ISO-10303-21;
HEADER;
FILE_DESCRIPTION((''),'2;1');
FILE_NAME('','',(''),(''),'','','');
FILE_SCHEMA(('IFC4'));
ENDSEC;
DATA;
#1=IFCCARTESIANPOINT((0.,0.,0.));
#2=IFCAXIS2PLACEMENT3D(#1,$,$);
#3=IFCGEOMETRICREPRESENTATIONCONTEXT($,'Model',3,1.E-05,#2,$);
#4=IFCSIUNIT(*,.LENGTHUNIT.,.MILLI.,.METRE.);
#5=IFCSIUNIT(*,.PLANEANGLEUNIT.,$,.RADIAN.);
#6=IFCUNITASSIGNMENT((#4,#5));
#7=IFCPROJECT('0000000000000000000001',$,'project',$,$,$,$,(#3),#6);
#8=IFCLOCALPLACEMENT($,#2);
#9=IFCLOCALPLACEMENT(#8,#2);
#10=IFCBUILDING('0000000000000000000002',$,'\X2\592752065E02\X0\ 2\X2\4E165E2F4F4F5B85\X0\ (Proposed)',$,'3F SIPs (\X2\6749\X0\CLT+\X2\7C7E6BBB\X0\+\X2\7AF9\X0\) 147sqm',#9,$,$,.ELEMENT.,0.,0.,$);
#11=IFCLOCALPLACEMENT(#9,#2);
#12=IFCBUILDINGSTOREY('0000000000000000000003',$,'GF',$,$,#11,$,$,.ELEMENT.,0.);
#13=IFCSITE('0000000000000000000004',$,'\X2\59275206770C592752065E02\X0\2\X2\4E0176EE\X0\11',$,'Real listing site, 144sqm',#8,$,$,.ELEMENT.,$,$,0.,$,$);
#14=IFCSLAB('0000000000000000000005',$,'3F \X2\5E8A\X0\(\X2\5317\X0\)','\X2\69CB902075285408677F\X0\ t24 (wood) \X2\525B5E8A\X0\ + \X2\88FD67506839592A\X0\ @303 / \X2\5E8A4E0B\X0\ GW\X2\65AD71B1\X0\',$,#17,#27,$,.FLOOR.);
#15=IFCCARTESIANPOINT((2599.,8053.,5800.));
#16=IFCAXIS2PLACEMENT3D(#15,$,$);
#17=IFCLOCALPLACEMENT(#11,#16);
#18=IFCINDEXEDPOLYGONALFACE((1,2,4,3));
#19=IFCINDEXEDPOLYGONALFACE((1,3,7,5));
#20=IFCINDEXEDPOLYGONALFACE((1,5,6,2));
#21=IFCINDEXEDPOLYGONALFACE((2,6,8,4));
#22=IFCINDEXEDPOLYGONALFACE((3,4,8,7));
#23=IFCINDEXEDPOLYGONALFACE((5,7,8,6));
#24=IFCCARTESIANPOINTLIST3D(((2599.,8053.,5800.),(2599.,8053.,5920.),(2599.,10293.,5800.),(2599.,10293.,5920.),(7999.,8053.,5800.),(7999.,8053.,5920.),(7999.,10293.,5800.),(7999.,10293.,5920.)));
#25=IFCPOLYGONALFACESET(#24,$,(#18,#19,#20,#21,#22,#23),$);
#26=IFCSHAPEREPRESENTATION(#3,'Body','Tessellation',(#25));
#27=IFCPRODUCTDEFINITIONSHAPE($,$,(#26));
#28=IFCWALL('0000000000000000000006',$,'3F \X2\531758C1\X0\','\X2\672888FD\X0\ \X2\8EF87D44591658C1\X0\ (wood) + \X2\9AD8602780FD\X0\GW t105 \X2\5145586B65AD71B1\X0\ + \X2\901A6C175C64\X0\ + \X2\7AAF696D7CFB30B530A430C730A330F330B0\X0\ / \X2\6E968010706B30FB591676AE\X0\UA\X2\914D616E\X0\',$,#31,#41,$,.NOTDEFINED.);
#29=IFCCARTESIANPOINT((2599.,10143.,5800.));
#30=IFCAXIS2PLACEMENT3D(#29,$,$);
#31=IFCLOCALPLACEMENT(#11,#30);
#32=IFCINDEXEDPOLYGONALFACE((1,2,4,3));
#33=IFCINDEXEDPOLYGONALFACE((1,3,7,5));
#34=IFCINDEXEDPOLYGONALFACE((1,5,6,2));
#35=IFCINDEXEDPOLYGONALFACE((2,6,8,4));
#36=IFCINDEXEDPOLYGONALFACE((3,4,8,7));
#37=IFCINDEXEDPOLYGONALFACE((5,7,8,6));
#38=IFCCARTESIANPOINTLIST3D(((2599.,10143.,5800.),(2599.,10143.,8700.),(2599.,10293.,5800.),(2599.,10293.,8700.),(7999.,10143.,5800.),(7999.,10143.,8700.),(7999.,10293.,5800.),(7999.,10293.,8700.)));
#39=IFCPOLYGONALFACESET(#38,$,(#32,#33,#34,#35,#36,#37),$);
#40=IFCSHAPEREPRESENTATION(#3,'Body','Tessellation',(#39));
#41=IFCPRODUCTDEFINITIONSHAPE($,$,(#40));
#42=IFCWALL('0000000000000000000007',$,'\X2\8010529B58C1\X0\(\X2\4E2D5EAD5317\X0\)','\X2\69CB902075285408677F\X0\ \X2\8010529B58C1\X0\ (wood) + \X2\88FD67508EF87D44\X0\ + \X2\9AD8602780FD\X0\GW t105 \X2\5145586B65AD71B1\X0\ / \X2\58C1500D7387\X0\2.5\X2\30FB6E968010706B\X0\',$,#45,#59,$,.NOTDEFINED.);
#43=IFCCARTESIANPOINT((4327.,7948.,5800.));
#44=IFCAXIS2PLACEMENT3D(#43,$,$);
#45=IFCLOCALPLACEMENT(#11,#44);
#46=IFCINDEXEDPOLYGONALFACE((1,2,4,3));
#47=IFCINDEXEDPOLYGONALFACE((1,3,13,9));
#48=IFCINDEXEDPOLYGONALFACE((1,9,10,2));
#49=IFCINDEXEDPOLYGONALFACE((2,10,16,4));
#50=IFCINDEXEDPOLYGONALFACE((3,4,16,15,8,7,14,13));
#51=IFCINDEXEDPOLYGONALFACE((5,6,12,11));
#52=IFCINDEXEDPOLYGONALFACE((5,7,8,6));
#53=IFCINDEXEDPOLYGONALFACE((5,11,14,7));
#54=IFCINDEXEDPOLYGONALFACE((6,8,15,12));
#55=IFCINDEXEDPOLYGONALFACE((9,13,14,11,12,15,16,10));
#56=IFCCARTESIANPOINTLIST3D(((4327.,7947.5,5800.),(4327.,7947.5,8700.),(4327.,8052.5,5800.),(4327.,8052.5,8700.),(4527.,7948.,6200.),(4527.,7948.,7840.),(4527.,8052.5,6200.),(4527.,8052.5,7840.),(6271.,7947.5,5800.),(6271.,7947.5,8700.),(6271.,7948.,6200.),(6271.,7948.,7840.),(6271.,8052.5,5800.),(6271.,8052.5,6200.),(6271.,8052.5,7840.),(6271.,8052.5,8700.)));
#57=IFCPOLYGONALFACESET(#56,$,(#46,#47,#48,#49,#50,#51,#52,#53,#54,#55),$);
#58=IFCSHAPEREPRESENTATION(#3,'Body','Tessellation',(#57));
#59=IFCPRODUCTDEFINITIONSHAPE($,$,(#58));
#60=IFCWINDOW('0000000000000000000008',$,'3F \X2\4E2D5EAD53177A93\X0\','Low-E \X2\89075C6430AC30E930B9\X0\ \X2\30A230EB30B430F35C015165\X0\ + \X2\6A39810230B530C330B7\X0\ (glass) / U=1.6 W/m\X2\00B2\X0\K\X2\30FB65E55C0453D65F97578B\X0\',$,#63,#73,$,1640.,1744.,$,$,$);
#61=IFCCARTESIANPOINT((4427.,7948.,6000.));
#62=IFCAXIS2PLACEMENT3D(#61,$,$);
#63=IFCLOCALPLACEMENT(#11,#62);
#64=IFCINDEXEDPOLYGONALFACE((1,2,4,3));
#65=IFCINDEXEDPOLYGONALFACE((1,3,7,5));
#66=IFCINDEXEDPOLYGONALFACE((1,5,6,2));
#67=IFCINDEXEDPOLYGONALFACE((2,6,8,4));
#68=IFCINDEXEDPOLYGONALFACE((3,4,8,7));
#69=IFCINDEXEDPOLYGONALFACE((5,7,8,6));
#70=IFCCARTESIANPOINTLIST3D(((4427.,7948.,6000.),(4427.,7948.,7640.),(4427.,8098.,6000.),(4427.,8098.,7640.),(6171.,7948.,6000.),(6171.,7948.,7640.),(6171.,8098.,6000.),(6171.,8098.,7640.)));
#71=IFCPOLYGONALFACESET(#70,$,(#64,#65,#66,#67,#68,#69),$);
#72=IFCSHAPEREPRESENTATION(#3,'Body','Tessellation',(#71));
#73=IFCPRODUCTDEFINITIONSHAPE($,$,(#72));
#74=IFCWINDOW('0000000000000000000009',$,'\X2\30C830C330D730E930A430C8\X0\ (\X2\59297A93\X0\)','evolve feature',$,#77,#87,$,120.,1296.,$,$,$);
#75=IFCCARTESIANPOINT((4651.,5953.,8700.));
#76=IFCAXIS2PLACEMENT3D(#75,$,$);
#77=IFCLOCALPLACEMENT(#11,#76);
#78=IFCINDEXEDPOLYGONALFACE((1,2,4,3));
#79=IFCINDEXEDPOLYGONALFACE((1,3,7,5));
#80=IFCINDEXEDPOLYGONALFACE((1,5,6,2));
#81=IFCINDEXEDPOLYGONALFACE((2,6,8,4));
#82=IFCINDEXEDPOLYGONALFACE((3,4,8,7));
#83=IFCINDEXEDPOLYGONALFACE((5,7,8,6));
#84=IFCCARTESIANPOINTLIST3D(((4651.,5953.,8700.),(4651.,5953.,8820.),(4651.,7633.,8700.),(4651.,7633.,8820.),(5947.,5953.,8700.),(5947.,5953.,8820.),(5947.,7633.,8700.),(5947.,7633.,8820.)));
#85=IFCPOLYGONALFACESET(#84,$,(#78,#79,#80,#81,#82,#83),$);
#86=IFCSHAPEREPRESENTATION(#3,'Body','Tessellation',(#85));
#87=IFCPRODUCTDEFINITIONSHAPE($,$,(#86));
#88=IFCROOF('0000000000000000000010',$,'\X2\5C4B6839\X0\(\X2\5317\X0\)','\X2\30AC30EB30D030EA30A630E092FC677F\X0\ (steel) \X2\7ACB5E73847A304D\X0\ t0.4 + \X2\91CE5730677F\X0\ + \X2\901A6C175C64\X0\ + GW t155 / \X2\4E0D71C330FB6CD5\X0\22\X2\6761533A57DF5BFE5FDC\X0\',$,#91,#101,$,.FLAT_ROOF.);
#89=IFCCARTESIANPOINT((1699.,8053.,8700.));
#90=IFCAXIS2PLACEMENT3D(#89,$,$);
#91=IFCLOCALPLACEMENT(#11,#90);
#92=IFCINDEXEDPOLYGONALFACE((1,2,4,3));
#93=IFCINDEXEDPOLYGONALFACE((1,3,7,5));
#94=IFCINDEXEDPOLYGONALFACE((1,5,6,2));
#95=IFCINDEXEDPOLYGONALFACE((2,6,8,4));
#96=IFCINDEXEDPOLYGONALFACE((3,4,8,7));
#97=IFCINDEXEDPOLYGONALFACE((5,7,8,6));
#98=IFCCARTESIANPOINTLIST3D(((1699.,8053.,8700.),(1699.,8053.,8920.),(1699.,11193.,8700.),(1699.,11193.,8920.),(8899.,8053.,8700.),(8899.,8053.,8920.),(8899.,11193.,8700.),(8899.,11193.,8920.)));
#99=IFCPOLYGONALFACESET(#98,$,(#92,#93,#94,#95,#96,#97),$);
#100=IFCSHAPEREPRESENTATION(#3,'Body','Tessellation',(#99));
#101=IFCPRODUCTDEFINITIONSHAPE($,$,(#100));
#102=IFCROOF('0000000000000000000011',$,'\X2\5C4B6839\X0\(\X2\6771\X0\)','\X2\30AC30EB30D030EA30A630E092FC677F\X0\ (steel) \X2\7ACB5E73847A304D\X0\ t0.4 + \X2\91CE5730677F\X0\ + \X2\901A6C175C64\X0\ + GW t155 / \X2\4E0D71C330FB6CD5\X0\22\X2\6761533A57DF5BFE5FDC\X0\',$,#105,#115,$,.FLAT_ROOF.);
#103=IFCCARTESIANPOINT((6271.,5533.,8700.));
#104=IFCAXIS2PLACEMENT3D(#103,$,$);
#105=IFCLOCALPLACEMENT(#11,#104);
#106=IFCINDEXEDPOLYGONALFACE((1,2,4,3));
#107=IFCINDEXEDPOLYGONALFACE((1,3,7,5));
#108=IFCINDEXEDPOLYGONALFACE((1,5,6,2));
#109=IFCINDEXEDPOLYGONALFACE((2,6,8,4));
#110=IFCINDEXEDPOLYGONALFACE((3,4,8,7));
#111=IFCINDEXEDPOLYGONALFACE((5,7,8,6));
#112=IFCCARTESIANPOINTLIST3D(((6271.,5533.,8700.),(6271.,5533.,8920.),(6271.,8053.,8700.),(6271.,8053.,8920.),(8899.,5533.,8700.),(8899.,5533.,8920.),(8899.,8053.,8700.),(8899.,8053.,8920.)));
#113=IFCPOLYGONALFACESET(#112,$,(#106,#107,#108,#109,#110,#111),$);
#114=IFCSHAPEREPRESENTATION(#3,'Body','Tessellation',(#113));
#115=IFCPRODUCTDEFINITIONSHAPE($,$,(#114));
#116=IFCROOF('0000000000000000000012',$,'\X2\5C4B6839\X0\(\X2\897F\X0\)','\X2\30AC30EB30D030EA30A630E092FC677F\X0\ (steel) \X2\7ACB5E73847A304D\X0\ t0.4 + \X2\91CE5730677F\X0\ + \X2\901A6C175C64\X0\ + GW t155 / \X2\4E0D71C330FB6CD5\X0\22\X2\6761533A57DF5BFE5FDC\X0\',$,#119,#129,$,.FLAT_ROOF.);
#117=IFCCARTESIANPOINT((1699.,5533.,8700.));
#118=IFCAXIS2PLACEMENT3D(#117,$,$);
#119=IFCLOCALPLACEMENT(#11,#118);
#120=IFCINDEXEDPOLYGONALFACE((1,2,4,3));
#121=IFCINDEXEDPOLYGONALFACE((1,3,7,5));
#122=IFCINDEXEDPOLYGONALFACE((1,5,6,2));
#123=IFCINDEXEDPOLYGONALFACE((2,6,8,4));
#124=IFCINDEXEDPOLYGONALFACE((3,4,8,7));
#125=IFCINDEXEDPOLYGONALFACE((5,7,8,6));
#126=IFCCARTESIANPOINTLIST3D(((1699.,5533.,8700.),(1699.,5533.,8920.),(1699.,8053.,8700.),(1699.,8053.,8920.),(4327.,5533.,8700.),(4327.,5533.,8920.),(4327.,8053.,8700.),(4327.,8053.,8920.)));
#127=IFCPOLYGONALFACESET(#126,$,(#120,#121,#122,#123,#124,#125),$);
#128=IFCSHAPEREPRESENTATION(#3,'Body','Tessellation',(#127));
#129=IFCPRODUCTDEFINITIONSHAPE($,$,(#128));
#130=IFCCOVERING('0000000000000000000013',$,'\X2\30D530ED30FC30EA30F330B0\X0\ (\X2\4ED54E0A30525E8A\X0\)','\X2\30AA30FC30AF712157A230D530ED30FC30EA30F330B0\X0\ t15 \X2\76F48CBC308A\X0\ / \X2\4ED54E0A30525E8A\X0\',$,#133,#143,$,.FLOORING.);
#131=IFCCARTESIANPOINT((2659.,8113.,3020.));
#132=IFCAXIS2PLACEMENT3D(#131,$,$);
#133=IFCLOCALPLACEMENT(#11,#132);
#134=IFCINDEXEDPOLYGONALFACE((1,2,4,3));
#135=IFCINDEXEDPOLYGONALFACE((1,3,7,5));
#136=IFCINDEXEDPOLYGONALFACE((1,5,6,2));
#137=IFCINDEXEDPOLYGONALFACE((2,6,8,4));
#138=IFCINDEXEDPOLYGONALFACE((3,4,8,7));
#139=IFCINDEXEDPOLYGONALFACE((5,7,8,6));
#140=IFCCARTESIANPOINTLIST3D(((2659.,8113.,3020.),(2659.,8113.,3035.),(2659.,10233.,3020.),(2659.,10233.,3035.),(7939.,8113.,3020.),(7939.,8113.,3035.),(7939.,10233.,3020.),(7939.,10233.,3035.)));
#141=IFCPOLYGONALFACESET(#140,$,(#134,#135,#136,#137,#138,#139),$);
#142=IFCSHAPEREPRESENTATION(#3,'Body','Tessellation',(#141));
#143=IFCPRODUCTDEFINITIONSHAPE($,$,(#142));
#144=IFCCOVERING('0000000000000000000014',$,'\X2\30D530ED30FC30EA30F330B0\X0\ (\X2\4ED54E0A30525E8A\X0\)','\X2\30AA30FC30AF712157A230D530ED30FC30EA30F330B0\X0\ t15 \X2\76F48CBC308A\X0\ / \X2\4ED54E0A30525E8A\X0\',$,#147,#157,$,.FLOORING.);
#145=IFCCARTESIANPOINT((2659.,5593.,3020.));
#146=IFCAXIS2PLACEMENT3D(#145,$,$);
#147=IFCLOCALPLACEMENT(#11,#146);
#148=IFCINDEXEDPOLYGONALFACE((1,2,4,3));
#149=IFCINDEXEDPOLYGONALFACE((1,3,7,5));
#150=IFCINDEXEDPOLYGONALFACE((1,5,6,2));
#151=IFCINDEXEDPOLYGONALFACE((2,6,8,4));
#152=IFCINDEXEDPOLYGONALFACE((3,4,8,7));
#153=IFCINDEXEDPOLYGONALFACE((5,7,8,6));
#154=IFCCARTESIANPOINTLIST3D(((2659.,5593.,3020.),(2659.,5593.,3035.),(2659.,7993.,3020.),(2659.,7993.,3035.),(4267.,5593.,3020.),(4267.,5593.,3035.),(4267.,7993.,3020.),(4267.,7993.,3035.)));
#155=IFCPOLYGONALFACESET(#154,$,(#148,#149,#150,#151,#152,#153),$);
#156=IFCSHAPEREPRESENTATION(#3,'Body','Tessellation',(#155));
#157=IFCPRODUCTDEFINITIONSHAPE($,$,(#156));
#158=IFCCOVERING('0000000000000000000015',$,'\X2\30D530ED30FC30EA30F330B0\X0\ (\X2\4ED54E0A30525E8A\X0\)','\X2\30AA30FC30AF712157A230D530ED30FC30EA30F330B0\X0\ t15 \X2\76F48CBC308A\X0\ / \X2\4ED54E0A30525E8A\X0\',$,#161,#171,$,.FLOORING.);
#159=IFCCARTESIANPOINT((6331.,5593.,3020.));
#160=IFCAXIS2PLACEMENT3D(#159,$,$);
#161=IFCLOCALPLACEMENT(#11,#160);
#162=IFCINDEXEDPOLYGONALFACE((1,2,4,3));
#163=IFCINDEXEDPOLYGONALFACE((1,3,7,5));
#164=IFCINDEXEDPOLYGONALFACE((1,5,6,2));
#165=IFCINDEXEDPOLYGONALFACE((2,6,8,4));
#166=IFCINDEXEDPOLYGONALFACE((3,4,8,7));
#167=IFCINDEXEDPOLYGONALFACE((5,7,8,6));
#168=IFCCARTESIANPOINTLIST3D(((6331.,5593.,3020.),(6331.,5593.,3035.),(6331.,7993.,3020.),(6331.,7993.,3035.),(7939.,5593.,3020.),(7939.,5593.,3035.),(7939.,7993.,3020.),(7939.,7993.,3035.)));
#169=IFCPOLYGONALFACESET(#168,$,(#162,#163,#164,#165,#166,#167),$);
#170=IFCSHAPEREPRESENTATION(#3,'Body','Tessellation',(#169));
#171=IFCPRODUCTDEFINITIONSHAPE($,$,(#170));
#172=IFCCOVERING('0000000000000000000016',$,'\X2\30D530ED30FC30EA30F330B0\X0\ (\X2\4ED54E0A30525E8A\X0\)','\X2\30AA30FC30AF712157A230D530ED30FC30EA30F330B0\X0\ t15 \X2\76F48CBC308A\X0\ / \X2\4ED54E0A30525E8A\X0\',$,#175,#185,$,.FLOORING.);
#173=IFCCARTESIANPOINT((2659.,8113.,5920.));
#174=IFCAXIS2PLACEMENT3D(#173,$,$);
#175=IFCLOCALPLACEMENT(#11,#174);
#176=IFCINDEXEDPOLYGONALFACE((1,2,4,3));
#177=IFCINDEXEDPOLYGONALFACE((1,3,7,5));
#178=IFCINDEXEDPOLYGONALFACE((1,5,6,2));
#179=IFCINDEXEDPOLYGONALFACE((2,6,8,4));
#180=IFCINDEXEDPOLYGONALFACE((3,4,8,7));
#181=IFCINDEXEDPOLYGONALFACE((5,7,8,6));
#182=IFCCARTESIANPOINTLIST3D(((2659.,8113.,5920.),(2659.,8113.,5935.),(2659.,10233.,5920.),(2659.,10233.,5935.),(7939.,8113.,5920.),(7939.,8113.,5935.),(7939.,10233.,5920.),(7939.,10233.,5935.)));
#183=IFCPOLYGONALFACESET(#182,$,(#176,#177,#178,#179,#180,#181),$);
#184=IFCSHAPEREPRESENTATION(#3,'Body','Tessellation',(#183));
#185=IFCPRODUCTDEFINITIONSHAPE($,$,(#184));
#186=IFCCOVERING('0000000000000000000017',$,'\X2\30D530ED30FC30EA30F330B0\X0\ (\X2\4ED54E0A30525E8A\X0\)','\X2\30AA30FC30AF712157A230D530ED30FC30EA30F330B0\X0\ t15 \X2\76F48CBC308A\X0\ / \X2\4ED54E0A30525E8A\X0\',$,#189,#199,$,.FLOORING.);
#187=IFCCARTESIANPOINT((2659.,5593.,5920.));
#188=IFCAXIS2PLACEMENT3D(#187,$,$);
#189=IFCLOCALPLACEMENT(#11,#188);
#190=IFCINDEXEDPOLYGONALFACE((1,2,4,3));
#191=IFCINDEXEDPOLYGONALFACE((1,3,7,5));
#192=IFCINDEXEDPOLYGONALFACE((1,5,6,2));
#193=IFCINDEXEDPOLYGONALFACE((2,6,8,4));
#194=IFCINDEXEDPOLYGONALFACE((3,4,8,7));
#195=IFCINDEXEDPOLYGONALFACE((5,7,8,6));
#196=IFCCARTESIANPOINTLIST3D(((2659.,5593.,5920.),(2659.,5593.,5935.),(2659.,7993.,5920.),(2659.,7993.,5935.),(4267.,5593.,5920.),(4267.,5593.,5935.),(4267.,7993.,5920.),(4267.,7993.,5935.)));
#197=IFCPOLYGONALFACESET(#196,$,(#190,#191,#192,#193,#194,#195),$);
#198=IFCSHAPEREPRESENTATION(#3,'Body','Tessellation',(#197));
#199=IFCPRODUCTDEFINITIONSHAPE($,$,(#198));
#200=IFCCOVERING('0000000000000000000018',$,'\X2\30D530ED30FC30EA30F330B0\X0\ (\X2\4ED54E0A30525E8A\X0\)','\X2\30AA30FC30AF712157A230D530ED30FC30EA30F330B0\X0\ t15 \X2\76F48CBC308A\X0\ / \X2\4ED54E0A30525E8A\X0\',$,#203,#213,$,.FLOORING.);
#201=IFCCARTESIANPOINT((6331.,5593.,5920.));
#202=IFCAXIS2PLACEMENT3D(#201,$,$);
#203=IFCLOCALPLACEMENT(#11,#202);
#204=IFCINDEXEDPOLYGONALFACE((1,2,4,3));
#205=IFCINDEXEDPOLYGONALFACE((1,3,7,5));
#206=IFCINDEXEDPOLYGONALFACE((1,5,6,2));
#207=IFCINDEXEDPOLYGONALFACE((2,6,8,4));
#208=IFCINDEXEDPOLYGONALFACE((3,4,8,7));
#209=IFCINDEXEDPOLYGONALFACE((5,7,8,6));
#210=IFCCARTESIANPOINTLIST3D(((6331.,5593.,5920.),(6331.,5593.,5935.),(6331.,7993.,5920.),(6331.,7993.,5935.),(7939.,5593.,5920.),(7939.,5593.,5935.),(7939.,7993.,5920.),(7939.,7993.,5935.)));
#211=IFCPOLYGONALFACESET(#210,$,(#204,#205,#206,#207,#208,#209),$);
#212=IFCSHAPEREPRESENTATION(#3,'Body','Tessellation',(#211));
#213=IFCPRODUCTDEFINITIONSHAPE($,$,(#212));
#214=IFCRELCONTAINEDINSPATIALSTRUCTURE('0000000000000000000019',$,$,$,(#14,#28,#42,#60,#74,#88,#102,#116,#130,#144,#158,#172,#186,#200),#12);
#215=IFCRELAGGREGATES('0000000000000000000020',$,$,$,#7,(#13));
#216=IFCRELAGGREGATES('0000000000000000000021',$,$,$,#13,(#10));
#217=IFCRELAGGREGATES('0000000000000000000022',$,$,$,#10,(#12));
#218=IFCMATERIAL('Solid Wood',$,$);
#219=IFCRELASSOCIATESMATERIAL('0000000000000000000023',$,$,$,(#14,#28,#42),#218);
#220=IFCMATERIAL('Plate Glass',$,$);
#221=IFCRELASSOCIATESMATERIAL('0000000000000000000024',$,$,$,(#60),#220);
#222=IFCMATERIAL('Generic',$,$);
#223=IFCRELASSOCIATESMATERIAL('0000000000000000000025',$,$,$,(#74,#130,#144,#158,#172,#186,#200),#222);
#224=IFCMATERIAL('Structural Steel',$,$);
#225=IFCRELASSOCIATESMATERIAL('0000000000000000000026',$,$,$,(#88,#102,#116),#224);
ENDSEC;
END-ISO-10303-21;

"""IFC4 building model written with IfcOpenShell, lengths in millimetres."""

from ifc_helpers import new_model, si_unit, frame, frame_2d, origin, place, context, project, spatial, rectangle, extrude, material, element, fill, save


model = new_model("IFC4")

# Units and contexts
model_context = context("Model", 3, precision=1e-05, world=origin())
ifc_project = project(units=[si_unit("LENGTHUNIT", "METRE", prefix="MILLI"), si_unit("PLANEANGLEUNIT", "RADIAN")], contexts=[model_context])

# Site, building, storey
site_placement = place(None, origin())
site = spatial("IfcSite", under=ifc_project, at=site_placement, Name="大分県大分市2丁目11", ObjectType="Real listing site, 144sqm", CompositionType="ELEMENT", RefElevation=0.0)
building_placement = place(site_placement, origin())
building = spatial("IfcBuilding", under=site, at=building_placement, Name="大分市 2世帯住宅 (Proposed)", ObjectType="3F SIPs (杉CLT+籾殻+竹) 147sqm", CompositionType="ELEMENT", ElevationOfRefHeight=0.0, ElevationOfTerrain=0.0)
storey_placement = place(building_placement, origin())
storey = spatial("IfcBuildingStorey", under=building, at=storey_placement, Name="GF", CompositionType="ELEMENT", Elevation=0.0)

# Slab
ifc_material_1 = material(Name="Solid Wood")
slab_placement = place(storey_placement, frame((2599.0, 8053.0, 5800.0)))
element("IfcSlab", 1, at=slab_placement, inside=storey, material=ifc_material_1, Name="3F 床(北)", Description="構造用合板 t24 (wood) 剛床 + 製材根太 @303 / 床下 GW断熱", PredefinedType="FLOOR", context=model_context, shape_type="SweptSolid", body=[
    extrude(rectangle(XDim=5400.0, YDim=2240.0, at=frame_2d((2700.0, 1120.0))), frame((2599.0, 8053.0, 5800.0)), (0.0, 0.0, 1.0), 120.0),
])

# Wall
wall_1_placement = place(storey_placement, frame((2599.0, 10143.0, 5800.0)))
element("IfcWall", 2, at=wall_1_placement, inside=storey, material=ifc_material_1, Name="3F 北壁", Description="木製 軸組外壁 (wood) + 高性能GW t105 充填断熱 + 通気層 + 窯業系サイディング / 準耐火・外皮UA配慮", PredefinedType="NOTDEFINED", context=model_context, shape_type="SweptSolid", body=[
    extrude(rectangle(XDim=5400.0, YDim=150.0, at=frame_2d((2700.0, 75.0))), frame((2599.0, 10143.0, 5800.0)), (0.0, 0.0, 1.0), 2900.0),
])

# Wall, opening, window
wall_2_placement = place(storey_placement, frame((4327.0, 7948.0, 5800.0)))
wall_2 = element("IfcWall", 3, at=wall_2_placement, inside=storey, material=ifc_material_1, Name="耐力壁(中庭北)", Description="構造用合板 耐力壁 (wood) + 製材軸組 + 高性能GW t105 充填断熱 / 壁倍率2.5・準耐火", PredefinedType="NOTDEFINED", context=model_context, shape_type="SweptSolid", body=[
    extrude(rectangle(XDim=1944.0, YDim=105.0, at=frame_2d((972.0, 52.0))), frame((4327.0, 7948.0, 5800.0)), (0.0, 0.0, 1.0), 2900.0),
])
opening_placement = place(storey_placement, frame((4427.0, 7948.0, 6000.0)))
opening = element("IfcOpeningElement", 4, at=opening_placement, cuts=wall_2, PredefinedType="NOTDEFINED", context=model_context, shape_type="SweptSolid", body=[
    extrude(rectangle(XDim=1744.0, YDim=150.0, at=frame_2d((872.0, 75.0))), frame((4427.0, 7948.0, 6000.0)), (0.0, 0.0, 1.0), 1640.0),
])
ifc_material_2 = material(Name="Plate Glass")
window_1_placement = place(storey_placement, frame((4427.0, 7948.0, 6000.0)))
window_1 = element("IfcWindow", 5, at=window_1_placement, inside=storey, material=ifc_material_2, Name="3F 中庭北窓", Description="Low-E 複層ガラス アルゴン封入 + 樹脂サッシ (glass) / U=1.6 W/m²K・日射取得型", OverallHeight=1640.0, OverallWidth=1744.0, context=model_context, shape_type="SweptSolid", body=[
    extrude(rectangle(XDim=1744.0, YDim=150.0, at=frame_2d((872.0, 75.0))), frame((4427.0, 7948.0, 6000.0)), (0.0, 0.0, 1.0), 1640.0),
])
fill(opening, window_1)

# Window
ifc_material_3 = material(Name="Generic")
window_2_placement = place(storey_placement, frame((4651.0, 5953.0, 8700.0)))
element("IfcWindow", 6, at=window_2_placement, inside=storey, material=ifc_material_3, Name="トップライト (天窓)", Description="evolve feature", OverallHeight=120.0, OverallWidth=1296.0, context=model_context, shape_type="SweptSolid", body=[
    extrude(rectangle(XDim=1296.0, YDim=1680.0, at=frame_2d((648.0, 840.0))), frame((4651.0, 5953.0, 8700.0)), (0.0, 0.0, 1.0), 120.0),
])

# Roofs
ifc_material_4 = material(Name="Structural Steel")
roof_1_placement = place(storey_placement, frame((1699.0, 8053.0, 8700.0)))
element("IfcRoof", 7, at=roof_1_placement, inside=storey, material=ifc_material_4, Name="屋根(北)", Description="ガルバリウム鋼板 (steel) 立平葺き t0.4 + 野地板 + 通気層 + GW t155 / 不燃・法22条区域対応", PredefinedType="FLAT_ROOF", context=model_context, shape_type="SweptSolid", body=[
    extrude(rectangle(XDim=7200.0, YDim=3140.0, at=frame_2d((3600.0, 1570.0))), frame((1699.0, 8053.0, 8700.0)), (0.0, 0.0, 1.0), 220.0),
])
roof_2_placement = place(storey_placement, frame((6271.0, 5533.0, 8700.0)))
element("IfcRoof", 8, at=roof_2_placement, inside=storey, material=ifc_material_4, Name="屋根(東)", Description="ガルバリウム鋼板 (steel) 立平葺き t0.4 + 野地板 + 通気層 + GW t155 / 不燃・法22条区域対応", PredefinedType="FLAT_ROOF", context=model_context, shape_type="SweptSolid", body=[
    extrude(rectangle(XDim=2628.0, YDim=2520.0, at=frame_2d((1314.0, 1260.0))), frame((6271.0, 5533.0, 8700.0)), (0.0, 0.0, 1.0), 220.0),
])
roof_3_placement = place(storey_placement, frame((1699.0, 5533.0, 8700.0)))
element("IfcRoof", 9, at=roof_3_placement, inside=storey, material=ifc_material_4, Name="屋根(西)", Description="ガルバリウム鋼板 (steel) 立平葺き t0.4 + 野地板 + 通気層 + GW t155 / 不燃・法22条区域対応", PredefinedType="FLAT_ROOF", context=model_context, shape_type="SweptSolid", body=[
    extrude(rectangle(XDim=2628.0, YDim=2520.0, at=frame_2d((1314.0, 1260.0))), frame((1699.0, 5533.0, 8700.0)), (0.0, 0.0, 1.0), 220.0),
])

# Coverings
covering_1_placement = place(storey_placement, frame((2659.0, 8113.0, 3020.0)))
element("IfcCovering", 10, at=covering_1_placement, inside=storey, material=ifc_material_3, Name="フローリング (仕上げ床)", Description="オーク無垢フローリング t15 直貼り / 仕上げ床", PredefinedType="FLOORING", context=model_context, shape_type="SweptSolid", body=[
    extrude(rectangle(XDim=5280.0, YDim=2120.0, at=frame_2d((2640.0, 1060.0))), frame((2659.0, 8113.0, 3020.0)), (0.0, 0.0, 1.0), 15.0),
])
covering_2_placement = place(storey_placement, frame((2659.0, 5593.0, 3020.0)))
element("IfcCovering", 11, at=covering_2_placement, inside=storey, material=ifc_material_3, Name="フローリング (仕上げ床)", Description="オーク無垢フローリング t15 直貼り / 仕上げ床", PredefinedType="FLOORING", context=model_context, shape_type="SweptSolid", body=[
    extrude(rectangle(XDim=1608.0, YDim=2400.0, at=frame_2d((804.0, 1200.0))), frame((2659.0, 5593.0, 3020.0)), (0.0, 0.0, 1.0), 15.0),
])
covering_3_placement = place(storey_placement, frame((6331.0, 5593.0, 3020.0)))
element("IfcCovering", 12, at=covering_3_placement, inside=storey, material=ifc_material_3, Name="フローリング (仕上げ床)", Description="オーク無垢フローリング t15 直貼り / 仕上げ床", PredefinedType="FLOORING", context=model_context, shape_type="SweptSolid", body=[
    extrude(rectangle(XDim=1608.0, YDim=2400.0, at=frame_2d((804.0, 1200.0))), frame((6331.0, 5593.0, 3020.0)), (0.0, 0.0, 1.0), 15.0),
])
covering_4_placement = place(storey_placement, frame((2659.0, 8113.0, 5920.0)))
element("IfcCovering", 13, at=covering_4_placement, inside=storey, material=ifc_material_3, Name="フローリング (仕上げ床)", Description="オーク無垢フローリング t15 直貼り / 仕上げ床", PredefinedType="FLOORING", context=model_context, shape_type="SweptSolid", body=[
    extrude(rectangle(XDim=5280.0, YDim=2120.0, at=frame_2d((2640.0, 1060.0))), frame((2659.0, 8113.0, 5920.0)), (0.0, 0.0, 1.0), 15.0),
])
covering_5_placement = place(storey_placement, frame((2659.0, 5593.0, 5920.0)))
element("IfcCovering", 14, at=covering_5_placement, inside=storey, material=ifc_material_3, Name="フローリング (仕上げ床)", Description="オーク無垢フローリング t15 直貼り / 仕上げ床", PredefinedType="FLOORING", context=model_context, shape_type="SweptSolid", body=[
    extrude(rectangle(XDim=1608.0, YDim=2400.0, at=frame_2d((804.0, 1200.0))), frame((2659.0, 5593.0, 5920.0)), (0.0, 0.0, 1.0), 15.0),
])
covering_6_placement = place(storey_placement, frame((6331.0, 5593.0, 5920.0)))
element("IfcCovering", 15, at=covering_6_placement, inside=storey, material=ifc_material_3, Name="フローリング (仕上げ床)", Description="オーク無垢フローリング t15 直貼り / 仕上げ床", PredefinedType="FLOORING", context=model_context, shape_type="SweptSolid", body=[
    extrude(rectangle(XDim=1608.0, YDim=2400.0, at=frame_2d((804.0, 1200.0))), frame((6331.0, 5593.0, 5920.0)), (0.0, 0.0, 1.0), 15.0),
])

save(model, "model.ifc")
